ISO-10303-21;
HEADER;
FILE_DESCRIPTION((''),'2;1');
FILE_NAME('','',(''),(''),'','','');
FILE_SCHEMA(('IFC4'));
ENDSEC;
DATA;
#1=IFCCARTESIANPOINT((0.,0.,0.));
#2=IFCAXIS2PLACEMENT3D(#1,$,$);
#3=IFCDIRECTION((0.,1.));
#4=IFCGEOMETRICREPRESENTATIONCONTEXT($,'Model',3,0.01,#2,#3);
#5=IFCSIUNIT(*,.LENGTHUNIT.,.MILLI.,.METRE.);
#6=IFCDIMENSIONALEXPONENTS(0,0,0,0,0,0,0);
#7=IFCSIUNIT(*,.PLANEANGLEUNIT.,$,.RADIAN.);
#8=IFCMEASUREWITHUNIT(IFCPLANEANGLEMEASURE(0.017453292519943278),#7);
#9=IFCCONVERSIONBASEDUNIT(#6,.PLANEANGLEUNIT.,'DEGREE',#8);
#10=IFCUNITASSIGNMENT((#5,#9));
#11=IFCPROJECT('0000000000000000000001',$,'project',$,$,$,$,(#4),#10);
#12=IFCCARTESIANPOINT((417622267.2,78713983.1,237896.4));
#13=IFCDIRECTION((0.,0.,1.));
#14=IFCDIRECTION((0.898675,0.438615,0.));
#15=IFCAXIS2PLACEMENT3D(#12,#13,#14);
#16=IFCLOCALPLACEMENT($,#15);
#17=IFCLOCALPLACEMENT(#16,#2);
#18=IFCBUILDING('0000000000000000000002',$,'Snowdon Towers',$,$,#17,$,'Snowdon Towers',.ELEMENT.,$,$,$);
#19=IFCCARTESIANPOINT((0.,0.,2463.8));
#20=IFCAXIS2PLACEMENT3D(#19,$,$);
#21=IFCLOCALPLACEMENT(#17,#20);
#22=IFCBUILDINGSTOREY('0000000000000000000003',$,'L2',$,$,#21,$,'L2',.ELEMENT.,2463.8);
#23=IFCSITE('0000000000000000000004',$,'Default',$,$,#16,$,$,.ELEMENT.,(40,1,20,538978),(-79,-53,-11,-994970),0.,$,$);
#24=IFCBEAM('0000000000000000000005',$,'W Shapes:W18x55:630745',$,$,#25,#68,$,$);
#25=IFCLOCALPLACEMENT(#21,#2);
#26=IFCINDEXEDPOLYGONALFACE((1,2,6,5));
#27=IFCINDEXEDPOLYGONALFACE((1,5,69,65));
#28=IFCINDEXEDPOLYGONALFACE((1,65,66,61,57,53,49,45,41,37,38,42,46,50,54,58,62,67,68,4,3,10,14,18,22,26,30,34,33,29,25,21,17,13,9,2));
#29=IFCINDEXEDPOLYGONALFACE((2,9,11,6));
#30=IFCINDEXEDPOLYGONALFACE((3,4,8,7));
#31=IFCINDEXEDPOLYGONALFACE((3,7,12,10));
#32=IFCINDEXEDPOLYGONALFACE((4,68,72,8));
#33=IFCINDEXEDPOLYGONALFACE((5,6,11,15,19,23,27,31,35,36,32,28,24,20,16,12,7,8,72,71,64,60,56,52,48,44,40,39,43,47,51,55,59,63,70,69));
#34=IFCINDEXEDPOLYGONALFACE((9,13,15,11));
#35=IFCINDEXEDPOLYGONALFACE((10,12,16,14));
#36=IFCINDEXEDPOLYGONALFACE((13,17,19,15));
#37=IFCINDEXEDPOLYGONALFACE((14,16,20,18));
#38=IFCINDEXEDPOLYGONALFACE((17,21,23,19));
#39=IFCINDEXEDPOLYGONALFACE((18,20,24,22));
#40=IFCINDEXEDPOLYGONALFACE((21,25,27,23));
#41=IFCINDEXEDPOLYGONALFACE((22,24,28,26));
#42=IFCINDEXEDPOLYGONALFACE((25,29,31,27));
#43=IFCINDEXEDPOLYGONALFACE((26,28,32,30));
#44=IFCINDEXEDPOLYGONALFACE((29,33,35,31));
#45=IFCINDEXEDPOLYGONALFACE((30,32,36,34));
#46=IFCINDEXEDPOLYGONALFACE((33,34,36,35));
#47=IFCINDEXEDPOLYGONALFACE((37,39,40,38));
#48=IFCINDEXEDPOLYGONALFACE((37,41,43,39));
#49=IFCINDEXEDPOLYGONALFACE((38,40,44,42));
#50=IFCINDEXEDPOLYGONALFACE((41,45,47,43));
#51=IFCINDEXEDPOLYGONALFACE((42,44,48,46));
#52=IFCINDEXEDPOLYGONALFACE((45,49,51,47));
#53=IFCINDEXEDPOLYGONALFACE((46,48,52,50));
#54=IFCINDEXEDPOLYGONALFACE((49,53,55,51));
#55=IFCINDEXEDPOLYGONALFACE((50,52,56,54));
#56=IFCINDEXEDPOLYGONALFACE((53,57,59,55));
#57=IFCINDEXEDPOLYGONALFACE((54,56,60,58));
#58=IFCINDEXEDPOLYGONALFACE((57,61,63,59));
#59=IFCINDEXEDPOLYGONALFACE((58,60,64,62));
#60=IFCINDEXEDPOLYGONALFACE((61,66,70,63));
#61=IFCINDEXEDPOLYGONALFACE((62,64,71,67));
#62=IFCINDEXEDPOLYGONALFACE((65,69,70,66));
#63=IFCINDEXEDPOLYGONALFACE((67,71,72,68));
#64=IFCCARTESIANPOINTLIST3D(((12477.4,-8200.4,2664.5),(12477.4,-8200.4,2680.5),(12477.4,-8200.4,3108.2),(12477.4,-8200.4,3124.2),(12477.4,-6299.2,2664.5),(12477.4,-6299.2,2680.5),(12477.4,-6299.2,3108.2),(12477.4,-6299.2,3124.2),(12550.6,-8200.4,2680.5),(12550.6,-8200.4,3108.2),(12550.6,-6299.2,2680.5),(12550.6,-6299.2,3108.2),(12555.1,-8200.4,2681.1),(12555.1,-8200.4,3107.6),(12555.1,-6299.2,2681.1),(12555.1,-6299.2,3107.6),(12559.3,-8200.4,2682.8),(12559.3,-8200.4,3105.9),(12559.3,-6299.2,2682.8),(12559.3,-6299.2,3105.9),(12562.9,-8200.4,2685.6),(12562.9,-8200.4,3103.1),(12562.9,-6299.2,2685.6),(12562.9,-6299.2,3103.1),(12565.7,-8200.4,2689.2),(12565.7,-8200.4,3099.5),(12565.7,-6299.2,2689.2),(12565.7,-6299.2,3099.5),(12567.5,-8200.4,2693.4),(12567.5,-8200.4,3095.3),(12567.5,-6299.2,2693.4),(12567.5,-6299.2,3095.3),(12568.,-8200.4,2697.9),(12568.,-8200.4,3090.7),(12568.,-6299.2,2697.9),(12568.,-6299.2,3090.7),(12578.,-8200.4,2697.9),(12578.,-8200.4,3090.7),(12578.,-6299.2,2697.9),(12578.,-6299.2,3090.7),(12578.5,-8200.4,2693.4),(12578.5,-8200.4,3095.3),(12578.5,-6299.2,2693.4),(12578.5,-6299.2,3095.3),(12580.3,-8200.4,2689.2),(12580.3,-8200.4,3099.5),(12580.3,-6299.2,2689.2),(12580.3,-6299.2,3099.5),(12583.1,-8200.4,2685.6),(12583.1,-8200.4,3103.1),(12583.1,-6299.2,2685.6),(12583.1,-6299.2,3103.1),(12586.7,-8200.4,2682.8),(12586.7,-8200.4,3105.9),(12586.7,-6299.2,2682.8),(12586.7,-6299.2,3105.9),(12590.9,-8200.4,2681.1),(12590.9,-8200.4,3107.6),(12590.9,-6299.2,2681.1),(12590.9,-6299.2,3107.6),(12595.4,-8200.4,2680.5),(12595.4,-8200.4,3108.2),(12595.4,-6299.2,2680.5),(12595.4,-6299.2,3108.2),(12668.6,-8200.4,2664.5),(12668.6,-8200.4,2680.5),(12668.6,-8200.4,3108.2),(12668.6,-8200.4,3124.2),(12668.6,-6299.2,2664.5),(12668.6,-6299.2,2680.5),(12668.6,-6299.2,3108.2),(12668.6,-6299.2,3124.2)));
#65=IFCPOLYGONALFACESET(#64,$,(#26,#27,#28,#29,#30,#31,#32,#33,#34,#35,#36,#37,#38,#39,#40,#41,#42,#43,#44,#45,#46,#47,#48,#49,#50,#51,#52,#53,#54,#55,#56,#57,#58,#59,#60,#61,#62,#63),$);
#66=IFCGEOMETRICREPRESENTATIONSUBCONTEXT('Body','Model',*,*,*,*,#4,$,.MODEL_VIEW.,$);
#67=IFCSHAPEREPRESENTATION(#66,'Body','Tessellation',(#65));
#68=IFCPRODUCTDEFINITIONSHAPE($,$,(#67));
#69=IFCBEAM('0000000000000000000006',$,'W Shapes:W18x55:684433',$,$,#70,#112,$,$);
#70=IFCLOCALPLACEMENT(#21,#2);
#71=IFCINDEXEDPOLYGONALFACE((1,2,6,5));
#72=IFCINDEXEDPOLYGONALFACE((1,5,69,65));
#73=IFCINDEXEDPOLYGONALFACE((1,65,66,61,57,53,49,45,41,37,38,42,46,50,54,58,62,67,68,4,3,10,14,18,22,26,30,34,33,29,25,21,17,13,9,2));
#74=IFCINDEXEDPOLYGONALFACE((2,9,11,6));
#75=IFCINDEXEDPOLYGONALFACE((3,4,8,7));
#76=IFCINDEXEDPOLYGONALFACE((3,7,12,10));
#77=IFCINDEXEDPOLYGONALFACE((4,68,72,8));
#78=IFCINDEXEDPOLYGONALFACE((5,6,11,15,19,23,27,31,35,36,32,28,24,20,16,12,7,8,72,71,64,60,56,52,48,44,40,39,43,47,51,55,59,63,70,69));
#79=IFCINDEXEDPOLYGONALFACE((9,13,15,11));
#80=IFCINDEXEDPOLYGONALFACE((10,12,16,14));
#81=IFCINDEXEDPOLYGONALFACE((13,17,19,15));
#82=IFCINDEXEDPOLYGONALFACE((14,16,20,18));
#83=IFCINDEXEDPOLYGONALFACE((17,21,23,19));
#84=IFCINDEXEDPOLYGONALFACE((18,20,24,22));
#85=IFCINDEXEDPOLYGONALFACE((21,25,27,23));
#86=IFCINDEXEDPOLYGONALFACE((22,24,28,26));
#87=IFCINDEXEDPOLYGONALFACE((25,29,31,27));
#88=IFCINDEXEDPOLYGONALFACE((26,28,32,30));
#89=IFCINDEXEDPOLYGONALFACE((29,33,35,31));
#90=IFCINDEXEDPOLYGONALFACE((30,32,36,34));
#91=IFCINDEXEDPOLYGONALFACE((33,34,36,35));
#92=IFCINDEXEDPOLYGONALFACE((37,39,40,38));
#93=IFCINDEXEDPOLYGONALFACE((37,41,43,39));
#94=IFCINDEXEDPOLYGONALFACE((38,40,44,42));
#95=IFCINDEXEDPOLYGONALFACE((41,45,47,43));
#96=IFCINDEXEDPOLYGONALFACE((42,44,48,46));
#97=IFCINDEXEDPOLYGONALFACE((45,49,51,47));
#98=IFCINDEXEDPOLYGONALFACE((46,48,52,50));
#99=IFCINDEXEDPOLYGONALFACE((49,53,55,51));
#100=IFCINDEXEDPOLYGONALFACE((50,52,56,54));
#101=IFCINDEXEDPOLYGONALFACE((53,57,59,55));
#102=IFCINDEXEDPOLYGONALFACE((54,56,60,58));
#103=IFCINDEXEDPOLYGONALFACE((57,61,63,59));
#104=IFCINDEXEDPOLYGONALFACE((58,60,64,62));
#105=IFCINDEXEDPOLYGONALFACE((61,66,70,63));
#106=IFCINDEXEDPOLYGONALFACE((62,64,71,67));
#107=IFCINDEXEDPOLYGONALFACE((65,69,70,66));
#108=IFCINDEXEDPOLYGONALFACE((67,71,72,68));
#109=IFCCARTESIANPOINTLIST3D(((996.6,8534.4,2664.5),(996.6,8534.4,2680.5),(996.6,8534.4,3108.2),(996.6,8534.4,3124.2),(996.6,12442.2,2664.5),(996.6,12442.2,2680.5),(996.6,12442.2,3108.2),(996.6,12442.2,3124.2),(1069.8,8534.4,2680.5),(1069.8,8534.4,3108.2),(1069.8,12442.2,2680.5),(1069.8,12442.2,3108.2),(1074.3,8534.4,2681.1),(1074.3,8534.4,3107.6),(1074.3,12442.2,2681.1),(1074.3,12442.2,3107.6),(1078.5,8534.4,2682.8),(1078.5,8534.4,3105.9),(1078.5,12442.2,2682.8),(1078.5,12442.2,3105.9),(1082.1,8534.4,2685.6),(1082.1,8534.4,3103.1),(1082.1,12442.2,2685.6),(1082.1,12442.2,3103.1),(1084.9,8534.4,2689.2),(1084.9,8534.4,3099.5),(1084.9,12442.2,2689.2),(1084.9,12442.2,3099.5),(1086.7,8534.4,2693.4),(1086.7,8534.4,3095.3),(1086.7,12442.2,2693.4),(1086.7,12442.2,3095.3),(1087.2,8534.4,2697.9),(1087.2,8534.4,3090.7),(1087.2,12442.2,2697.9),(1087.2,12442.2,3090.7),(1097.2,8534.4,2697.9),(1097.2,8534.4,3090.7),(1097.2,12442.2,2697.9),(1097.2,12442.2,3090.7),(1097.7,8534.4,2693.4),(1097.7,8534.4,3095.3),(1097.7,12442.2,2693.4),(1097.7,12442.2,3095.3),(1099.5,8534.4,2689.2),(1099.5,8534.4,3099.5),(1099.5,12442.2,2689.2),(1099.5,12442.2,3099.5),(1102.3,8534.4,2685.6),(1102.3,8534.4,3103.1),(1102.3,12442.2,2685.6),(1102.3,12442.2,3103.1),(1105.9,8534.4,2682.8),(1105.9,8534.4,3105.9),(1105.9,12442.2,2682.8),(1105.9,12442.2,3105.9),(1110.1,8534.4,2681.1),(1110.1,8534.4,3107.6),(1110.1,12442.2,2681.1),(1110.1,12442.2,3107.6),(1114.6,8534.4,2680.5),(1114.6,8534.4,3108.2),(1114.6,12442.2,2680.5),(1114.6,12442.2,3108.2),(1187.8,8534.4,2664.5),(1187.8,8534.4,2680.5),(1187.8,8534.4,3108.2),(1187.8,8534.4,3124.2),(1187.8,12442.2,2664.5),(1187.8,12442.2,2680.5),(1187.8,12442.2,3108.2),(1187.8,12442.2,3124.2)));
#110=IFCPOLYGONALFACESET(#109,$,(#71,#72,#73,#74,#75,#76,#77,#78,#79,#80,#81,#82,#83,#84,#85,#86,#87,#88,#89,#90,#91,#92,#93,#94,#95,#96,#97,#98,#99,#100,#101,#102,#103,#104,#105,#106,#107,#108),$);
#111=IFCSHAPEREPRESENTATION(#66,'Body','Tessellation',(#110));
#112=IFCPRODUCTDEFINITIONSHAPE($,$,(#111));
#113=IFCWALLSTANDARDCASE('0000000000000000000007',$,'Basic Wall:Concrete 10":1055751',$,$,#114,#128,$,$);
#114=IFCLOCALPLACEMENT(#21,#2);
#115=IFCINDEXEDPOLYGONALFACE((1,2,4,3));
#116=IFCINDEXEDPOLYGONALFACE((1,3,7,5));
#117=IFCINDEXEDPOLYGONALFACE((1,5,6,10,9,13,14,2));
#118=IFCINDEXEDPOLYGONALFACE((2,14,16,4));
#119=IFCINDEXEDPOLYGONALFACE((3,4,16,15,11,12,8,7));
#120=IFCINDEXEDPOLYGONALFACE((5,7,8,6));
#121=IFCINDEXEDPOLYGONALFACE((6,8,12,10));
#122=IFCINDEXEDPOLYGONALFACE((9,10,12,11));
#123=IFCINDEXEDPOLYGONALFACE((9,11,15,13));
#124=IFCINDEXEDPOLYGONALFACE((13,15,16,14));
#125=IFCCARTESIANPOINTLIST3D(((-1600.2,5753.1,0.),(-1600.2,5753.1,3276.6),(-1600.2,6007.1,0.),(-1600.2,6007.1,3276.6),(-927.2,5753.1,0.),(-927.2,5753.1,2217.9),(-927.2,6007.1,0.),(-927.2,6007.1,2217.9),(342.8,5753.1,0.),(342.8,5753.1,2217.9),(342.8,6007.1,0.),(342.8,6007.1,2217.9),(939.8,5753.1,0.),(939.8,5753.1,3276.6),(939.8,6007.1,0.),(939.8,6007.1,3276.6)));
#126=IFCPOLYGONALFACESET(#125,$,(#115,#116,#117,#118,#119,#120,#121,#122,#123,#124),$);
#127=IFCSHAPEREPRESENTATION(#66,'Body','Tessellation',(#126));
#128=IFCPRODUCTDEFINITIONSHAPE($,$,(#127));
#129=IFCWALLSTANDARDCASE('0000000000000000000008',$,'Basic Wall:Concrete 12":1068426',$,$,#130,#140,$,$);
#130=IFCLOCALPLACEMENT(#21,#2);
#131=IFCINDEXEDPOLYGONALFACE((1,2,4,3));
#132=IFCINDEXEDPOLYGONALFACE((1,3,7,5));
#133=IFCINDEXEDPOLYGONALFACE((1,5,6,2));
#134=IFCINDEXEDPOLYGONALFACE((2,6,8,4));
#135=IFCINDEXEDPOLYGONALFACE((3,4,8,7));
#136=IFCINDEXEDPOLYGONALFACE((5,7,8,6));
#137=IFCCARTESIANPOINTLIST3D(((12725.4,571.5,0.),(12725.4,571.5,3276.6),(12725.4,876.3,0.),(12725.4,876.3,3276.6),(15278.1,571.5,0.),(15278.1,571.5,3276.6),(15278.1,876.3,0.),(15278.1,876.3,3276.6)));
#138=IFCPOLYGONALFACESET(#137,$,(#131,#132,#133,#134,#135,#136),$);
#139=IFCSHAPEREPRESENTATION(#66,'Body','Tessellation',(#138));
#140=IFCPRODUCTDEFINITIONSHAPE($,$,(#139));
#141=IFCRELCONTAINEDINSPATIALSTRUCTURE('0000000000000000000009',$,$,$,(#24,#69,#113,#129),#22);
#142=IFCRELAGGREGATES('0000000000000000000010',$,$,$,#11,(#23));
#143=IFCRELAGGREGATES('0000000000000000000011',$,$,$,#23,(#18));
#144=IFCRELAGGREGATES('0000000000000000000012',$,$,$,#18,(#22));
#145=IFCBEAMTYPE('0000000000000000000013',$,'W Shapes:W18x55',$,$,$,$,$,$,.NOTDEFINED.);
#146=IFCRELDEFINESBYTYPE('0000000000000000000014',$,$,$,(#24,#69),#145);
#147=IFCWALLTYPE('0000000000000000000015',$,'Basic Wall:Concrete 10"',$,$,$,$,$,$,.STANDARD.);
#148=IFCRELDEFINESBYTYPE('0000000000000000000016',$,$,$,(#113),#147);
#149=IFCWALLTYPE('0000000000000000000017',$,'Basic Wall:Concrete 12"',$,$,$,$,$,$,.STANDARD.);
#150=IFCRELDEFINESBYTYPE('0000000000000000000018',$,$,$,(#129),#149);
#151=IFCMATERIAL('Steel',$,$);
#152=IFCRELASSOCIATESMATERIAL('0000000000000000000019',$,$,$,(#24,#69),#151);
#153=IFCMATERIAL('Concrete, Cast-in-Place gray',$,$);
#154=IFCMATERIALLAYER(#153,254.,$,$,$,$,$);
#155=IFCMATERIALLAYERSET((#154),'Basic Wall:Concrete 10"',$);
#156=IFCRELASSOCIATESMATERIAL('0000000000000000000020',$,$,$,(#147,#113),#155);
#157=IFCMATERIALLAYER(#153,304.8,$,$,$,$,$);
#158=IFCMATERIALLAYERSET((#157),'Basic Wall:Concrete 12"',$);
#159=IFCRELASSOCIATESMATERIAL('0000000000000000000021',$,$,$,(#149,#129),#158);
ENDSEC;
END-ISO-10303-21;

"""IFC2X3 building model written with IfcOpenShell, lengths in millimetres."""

from ifc_helpers import new_model, entity, si_unit, converted_unit, direction, frame, frame_2d, origin, place, context, subcontext, project, spatial, rectangle, i_section, extrude, material, layer, layer_set, layer_usage, type_object, element, save


model = new_model("IFC2X3")

# Units and contexts
model_context = context("Model", 3, precision=0.01, world=origin(), true_north=direction((0.0, 1.0)))
body_context = subcontext(model_context, "Body", "Model", "MODEL_VIEW")
ifc_project = project(units=[si_unit("LENGTHUNIT", "METRE", prefix="MILLI"), converted_unit("PLANEANGLEUNIT", "DEGREE", entity("IfcPlaneAngleMeasure", 0.017453292519943278), si_unit("PLANEANGLEUNIT", "RADIAN"), dimensions=[0, 0, 0, 0, 0, 0, 0])], contexts=[model_context])

# Site, building, storey
site_placement = place(None, frame((417622267.2, 78713983.1, 237896.4), z_axis=(0.0, 0.0, 1.0), x_axis=(0.898675, 0.438615, 0.0)))
site = spatial("IfcSite", under=ifc_project, at=site_placement, Name="Default", CompositionType="ELEMENT", RefLatitude=(40, 1, 20, 538978), RefLongitude=(-79, -53, -11, -994970), RefElevation=0.0)
building_placement = place(site_placement, origin())
building = spatial("IfcBuilding", under=site, at=building_placement, Name="Snowdon Towers", LongName="Snowdon Towers", CompositionType="ELEMENT")
storey_placement = place(building_placement, frame((0.0, 0.0, 2463.8)))
storey = spatial("IfcBuildingStorey", under=building, at=storey_placement, Name="L2", LongName="L2", CompositionType="ELEMENT", Elevation=2463.8)

# Shared definitions
ifc_material_1 = material(Name="Steel")

# Beams
beam_type_1 = type_object("IfcBeamType", Name="W Shapes:W18x55", PredefinedType="NOTDEFINED")
beam_1_placement = place(storey_placement, frame((12573.0, -6134.1, 3124.2), z_axis=(0.0, 0.0, 1.0), x_axis=(0.0, -1.0, 0.0)))
element("IfcBeam", 1, at=beam_1_placement, inside=storey, type_object=beam_type_1, material=ifc_material_1, Name="W Shapes:W18x55:630745", context=body_context, shape_type="SweptSolid", body=[
    extrude(i_section(OverallWidth=191.3, OverallDepth=459.7, WebThickness=9.9, FlangeThickness=16.0, FilletRadius=17.5, at=frame_2d((0.0, 0.0), x_axis=(0.0, 1.0))), frame((165.1, 0.0, -229.9), z_axis=(1.0, 0.0, 0.0), x_axis=(0.0, 0.0, -1.0)), (0.0, 0.0, 1.0), 1901.2),
])
beam_2_placement = place(storey_placement, frame((1092.2, 12636.5, 3124.2), z_axis=(0.0, 0.0, 1.0), x_axis=(0.0, -1.0, 0.0)))
element("IfcBeam", 2, at=beam_2_placement, inside=storey, type_object=beam_type_1, material=ifc_material_1, Name="W Shapes:W18x55:684433", context=body_context, shape_type="SweptSolid", body=[
    extrude(i_section(OverallWidth=191.3, OverallDepth=459.7, WebThickness=9.9, FlangeThickness=16.0, FilletRadius=17.5, at=frame_2d((0.0, 0.0), x_axis=(0.0, 1.0))), frame((194.3, 0.0, -229.9), z_axis=(1.0, 0.0, 0.0), x_axis=(0.0, 0.0, -1.0)), (0.0, 0.0, 1.0), 3907.8),
])

# Wall, opening
ifc_material_2 = material(Name="Concrete, Cast-in-Place gray")
ifc_layer_1 = layer(ifc_material_2, 254.0)
ifc_layer_set_1 = layer_set([ifc_layer_1], Name="Basic Wall:Concrete 10\"")
ifc_layer_usage_1 = layer_usage(ifc_layer_set_1, "AXIS2", "POSITIVE", -127.0)
wall_type_1 = type_object("IfcWallType", Name="Basic Wall:Concrete 10\"", PredefinedType="STANDARD", material=ifc_layer_set_1)
wall_1_placement = place(storey_placement, frame((939.8, 5880.1, 0.0), z_axis=(0.0, 0.0, 1.0), x_axis=(-1.0, 0.0, 0.0)))
wall_1 = element("IfcWallStandardCase", 3, at=wall_1_placement, inside=storey, type_object=wall_type_1, material=ifc_layer_usage_1, Name="Basic Wall:Concrete 10\":1055751", context=body_context, shape_type="SweptSolid", body=[
    extrude(rectangle(XDim=2540.0, YDim=254.0, at=frame_2d((1270.0, 0.0), x_axis=(-1.0, 0.0))), origin(), (0.0, 0.0, 1.0), 3276.6),
])
opening_placement = place(wall_1_placement, origin())
element("IfcOpeningElement", 4, at=opening_placement, cuts=wall_1, ObjectType="Opening", context=body_context, shape_type="SweptSolid", body=[
    extrude(rectangle(XDim=2217.9, YDim=1270.0, at=frame_2d((0.0, 0.0), x_axis=(0.0, 1.0))), frame((1232.0, 127.0, 1108.9), z_axis=(0.0, -1.0, 0.0), x_axis=(1.0, 0.0, 0.0)), (0.0, 0.0, 1.0), 254.0),
])

# Wall
ifc_layer_2 = layer(ifc_material_2, 304.8)
ifc_layer_set_2 = layer_set([ifc_layer_2], Name="Basic Wall:Concrete 12\"")
ifc_layer_usage_2 = layer_usage(ifc_layer_set_2, "AXIS2", "POSITIVE", -152.4)
wall_type_2 = type_object("IfcWallType", Name="Basic Wall:Concrete 12\"", PredefinedType="STANDARD", material=ifc_layer_set_2)
wall_2_placement = place(storey_placement, frame((15278.1, 723.9, 0.0), z_axis=(0.0, 0.0, 1.0), x_axis=(-1.0, 0.0, 0.0)))
element("IfcWallStandardCase", 5, at=wall_2_placement, inside=storey, type_object=wall_type_2, material=ifc_layer_usage_2, Name="Basic Wall:Concrete 12\":1068426", context=body_context, shape_type="SweptSolid", body=[
    extrude(rectangle(XDim=2552.7, YDim=304.8, at=frame_2d((1276.3, 0.0), x_axis=(-1.0, 0.0))), origin(), (0.0, 0.0, 1.0), 3276.6),
])

save(model, "model.ifc")
